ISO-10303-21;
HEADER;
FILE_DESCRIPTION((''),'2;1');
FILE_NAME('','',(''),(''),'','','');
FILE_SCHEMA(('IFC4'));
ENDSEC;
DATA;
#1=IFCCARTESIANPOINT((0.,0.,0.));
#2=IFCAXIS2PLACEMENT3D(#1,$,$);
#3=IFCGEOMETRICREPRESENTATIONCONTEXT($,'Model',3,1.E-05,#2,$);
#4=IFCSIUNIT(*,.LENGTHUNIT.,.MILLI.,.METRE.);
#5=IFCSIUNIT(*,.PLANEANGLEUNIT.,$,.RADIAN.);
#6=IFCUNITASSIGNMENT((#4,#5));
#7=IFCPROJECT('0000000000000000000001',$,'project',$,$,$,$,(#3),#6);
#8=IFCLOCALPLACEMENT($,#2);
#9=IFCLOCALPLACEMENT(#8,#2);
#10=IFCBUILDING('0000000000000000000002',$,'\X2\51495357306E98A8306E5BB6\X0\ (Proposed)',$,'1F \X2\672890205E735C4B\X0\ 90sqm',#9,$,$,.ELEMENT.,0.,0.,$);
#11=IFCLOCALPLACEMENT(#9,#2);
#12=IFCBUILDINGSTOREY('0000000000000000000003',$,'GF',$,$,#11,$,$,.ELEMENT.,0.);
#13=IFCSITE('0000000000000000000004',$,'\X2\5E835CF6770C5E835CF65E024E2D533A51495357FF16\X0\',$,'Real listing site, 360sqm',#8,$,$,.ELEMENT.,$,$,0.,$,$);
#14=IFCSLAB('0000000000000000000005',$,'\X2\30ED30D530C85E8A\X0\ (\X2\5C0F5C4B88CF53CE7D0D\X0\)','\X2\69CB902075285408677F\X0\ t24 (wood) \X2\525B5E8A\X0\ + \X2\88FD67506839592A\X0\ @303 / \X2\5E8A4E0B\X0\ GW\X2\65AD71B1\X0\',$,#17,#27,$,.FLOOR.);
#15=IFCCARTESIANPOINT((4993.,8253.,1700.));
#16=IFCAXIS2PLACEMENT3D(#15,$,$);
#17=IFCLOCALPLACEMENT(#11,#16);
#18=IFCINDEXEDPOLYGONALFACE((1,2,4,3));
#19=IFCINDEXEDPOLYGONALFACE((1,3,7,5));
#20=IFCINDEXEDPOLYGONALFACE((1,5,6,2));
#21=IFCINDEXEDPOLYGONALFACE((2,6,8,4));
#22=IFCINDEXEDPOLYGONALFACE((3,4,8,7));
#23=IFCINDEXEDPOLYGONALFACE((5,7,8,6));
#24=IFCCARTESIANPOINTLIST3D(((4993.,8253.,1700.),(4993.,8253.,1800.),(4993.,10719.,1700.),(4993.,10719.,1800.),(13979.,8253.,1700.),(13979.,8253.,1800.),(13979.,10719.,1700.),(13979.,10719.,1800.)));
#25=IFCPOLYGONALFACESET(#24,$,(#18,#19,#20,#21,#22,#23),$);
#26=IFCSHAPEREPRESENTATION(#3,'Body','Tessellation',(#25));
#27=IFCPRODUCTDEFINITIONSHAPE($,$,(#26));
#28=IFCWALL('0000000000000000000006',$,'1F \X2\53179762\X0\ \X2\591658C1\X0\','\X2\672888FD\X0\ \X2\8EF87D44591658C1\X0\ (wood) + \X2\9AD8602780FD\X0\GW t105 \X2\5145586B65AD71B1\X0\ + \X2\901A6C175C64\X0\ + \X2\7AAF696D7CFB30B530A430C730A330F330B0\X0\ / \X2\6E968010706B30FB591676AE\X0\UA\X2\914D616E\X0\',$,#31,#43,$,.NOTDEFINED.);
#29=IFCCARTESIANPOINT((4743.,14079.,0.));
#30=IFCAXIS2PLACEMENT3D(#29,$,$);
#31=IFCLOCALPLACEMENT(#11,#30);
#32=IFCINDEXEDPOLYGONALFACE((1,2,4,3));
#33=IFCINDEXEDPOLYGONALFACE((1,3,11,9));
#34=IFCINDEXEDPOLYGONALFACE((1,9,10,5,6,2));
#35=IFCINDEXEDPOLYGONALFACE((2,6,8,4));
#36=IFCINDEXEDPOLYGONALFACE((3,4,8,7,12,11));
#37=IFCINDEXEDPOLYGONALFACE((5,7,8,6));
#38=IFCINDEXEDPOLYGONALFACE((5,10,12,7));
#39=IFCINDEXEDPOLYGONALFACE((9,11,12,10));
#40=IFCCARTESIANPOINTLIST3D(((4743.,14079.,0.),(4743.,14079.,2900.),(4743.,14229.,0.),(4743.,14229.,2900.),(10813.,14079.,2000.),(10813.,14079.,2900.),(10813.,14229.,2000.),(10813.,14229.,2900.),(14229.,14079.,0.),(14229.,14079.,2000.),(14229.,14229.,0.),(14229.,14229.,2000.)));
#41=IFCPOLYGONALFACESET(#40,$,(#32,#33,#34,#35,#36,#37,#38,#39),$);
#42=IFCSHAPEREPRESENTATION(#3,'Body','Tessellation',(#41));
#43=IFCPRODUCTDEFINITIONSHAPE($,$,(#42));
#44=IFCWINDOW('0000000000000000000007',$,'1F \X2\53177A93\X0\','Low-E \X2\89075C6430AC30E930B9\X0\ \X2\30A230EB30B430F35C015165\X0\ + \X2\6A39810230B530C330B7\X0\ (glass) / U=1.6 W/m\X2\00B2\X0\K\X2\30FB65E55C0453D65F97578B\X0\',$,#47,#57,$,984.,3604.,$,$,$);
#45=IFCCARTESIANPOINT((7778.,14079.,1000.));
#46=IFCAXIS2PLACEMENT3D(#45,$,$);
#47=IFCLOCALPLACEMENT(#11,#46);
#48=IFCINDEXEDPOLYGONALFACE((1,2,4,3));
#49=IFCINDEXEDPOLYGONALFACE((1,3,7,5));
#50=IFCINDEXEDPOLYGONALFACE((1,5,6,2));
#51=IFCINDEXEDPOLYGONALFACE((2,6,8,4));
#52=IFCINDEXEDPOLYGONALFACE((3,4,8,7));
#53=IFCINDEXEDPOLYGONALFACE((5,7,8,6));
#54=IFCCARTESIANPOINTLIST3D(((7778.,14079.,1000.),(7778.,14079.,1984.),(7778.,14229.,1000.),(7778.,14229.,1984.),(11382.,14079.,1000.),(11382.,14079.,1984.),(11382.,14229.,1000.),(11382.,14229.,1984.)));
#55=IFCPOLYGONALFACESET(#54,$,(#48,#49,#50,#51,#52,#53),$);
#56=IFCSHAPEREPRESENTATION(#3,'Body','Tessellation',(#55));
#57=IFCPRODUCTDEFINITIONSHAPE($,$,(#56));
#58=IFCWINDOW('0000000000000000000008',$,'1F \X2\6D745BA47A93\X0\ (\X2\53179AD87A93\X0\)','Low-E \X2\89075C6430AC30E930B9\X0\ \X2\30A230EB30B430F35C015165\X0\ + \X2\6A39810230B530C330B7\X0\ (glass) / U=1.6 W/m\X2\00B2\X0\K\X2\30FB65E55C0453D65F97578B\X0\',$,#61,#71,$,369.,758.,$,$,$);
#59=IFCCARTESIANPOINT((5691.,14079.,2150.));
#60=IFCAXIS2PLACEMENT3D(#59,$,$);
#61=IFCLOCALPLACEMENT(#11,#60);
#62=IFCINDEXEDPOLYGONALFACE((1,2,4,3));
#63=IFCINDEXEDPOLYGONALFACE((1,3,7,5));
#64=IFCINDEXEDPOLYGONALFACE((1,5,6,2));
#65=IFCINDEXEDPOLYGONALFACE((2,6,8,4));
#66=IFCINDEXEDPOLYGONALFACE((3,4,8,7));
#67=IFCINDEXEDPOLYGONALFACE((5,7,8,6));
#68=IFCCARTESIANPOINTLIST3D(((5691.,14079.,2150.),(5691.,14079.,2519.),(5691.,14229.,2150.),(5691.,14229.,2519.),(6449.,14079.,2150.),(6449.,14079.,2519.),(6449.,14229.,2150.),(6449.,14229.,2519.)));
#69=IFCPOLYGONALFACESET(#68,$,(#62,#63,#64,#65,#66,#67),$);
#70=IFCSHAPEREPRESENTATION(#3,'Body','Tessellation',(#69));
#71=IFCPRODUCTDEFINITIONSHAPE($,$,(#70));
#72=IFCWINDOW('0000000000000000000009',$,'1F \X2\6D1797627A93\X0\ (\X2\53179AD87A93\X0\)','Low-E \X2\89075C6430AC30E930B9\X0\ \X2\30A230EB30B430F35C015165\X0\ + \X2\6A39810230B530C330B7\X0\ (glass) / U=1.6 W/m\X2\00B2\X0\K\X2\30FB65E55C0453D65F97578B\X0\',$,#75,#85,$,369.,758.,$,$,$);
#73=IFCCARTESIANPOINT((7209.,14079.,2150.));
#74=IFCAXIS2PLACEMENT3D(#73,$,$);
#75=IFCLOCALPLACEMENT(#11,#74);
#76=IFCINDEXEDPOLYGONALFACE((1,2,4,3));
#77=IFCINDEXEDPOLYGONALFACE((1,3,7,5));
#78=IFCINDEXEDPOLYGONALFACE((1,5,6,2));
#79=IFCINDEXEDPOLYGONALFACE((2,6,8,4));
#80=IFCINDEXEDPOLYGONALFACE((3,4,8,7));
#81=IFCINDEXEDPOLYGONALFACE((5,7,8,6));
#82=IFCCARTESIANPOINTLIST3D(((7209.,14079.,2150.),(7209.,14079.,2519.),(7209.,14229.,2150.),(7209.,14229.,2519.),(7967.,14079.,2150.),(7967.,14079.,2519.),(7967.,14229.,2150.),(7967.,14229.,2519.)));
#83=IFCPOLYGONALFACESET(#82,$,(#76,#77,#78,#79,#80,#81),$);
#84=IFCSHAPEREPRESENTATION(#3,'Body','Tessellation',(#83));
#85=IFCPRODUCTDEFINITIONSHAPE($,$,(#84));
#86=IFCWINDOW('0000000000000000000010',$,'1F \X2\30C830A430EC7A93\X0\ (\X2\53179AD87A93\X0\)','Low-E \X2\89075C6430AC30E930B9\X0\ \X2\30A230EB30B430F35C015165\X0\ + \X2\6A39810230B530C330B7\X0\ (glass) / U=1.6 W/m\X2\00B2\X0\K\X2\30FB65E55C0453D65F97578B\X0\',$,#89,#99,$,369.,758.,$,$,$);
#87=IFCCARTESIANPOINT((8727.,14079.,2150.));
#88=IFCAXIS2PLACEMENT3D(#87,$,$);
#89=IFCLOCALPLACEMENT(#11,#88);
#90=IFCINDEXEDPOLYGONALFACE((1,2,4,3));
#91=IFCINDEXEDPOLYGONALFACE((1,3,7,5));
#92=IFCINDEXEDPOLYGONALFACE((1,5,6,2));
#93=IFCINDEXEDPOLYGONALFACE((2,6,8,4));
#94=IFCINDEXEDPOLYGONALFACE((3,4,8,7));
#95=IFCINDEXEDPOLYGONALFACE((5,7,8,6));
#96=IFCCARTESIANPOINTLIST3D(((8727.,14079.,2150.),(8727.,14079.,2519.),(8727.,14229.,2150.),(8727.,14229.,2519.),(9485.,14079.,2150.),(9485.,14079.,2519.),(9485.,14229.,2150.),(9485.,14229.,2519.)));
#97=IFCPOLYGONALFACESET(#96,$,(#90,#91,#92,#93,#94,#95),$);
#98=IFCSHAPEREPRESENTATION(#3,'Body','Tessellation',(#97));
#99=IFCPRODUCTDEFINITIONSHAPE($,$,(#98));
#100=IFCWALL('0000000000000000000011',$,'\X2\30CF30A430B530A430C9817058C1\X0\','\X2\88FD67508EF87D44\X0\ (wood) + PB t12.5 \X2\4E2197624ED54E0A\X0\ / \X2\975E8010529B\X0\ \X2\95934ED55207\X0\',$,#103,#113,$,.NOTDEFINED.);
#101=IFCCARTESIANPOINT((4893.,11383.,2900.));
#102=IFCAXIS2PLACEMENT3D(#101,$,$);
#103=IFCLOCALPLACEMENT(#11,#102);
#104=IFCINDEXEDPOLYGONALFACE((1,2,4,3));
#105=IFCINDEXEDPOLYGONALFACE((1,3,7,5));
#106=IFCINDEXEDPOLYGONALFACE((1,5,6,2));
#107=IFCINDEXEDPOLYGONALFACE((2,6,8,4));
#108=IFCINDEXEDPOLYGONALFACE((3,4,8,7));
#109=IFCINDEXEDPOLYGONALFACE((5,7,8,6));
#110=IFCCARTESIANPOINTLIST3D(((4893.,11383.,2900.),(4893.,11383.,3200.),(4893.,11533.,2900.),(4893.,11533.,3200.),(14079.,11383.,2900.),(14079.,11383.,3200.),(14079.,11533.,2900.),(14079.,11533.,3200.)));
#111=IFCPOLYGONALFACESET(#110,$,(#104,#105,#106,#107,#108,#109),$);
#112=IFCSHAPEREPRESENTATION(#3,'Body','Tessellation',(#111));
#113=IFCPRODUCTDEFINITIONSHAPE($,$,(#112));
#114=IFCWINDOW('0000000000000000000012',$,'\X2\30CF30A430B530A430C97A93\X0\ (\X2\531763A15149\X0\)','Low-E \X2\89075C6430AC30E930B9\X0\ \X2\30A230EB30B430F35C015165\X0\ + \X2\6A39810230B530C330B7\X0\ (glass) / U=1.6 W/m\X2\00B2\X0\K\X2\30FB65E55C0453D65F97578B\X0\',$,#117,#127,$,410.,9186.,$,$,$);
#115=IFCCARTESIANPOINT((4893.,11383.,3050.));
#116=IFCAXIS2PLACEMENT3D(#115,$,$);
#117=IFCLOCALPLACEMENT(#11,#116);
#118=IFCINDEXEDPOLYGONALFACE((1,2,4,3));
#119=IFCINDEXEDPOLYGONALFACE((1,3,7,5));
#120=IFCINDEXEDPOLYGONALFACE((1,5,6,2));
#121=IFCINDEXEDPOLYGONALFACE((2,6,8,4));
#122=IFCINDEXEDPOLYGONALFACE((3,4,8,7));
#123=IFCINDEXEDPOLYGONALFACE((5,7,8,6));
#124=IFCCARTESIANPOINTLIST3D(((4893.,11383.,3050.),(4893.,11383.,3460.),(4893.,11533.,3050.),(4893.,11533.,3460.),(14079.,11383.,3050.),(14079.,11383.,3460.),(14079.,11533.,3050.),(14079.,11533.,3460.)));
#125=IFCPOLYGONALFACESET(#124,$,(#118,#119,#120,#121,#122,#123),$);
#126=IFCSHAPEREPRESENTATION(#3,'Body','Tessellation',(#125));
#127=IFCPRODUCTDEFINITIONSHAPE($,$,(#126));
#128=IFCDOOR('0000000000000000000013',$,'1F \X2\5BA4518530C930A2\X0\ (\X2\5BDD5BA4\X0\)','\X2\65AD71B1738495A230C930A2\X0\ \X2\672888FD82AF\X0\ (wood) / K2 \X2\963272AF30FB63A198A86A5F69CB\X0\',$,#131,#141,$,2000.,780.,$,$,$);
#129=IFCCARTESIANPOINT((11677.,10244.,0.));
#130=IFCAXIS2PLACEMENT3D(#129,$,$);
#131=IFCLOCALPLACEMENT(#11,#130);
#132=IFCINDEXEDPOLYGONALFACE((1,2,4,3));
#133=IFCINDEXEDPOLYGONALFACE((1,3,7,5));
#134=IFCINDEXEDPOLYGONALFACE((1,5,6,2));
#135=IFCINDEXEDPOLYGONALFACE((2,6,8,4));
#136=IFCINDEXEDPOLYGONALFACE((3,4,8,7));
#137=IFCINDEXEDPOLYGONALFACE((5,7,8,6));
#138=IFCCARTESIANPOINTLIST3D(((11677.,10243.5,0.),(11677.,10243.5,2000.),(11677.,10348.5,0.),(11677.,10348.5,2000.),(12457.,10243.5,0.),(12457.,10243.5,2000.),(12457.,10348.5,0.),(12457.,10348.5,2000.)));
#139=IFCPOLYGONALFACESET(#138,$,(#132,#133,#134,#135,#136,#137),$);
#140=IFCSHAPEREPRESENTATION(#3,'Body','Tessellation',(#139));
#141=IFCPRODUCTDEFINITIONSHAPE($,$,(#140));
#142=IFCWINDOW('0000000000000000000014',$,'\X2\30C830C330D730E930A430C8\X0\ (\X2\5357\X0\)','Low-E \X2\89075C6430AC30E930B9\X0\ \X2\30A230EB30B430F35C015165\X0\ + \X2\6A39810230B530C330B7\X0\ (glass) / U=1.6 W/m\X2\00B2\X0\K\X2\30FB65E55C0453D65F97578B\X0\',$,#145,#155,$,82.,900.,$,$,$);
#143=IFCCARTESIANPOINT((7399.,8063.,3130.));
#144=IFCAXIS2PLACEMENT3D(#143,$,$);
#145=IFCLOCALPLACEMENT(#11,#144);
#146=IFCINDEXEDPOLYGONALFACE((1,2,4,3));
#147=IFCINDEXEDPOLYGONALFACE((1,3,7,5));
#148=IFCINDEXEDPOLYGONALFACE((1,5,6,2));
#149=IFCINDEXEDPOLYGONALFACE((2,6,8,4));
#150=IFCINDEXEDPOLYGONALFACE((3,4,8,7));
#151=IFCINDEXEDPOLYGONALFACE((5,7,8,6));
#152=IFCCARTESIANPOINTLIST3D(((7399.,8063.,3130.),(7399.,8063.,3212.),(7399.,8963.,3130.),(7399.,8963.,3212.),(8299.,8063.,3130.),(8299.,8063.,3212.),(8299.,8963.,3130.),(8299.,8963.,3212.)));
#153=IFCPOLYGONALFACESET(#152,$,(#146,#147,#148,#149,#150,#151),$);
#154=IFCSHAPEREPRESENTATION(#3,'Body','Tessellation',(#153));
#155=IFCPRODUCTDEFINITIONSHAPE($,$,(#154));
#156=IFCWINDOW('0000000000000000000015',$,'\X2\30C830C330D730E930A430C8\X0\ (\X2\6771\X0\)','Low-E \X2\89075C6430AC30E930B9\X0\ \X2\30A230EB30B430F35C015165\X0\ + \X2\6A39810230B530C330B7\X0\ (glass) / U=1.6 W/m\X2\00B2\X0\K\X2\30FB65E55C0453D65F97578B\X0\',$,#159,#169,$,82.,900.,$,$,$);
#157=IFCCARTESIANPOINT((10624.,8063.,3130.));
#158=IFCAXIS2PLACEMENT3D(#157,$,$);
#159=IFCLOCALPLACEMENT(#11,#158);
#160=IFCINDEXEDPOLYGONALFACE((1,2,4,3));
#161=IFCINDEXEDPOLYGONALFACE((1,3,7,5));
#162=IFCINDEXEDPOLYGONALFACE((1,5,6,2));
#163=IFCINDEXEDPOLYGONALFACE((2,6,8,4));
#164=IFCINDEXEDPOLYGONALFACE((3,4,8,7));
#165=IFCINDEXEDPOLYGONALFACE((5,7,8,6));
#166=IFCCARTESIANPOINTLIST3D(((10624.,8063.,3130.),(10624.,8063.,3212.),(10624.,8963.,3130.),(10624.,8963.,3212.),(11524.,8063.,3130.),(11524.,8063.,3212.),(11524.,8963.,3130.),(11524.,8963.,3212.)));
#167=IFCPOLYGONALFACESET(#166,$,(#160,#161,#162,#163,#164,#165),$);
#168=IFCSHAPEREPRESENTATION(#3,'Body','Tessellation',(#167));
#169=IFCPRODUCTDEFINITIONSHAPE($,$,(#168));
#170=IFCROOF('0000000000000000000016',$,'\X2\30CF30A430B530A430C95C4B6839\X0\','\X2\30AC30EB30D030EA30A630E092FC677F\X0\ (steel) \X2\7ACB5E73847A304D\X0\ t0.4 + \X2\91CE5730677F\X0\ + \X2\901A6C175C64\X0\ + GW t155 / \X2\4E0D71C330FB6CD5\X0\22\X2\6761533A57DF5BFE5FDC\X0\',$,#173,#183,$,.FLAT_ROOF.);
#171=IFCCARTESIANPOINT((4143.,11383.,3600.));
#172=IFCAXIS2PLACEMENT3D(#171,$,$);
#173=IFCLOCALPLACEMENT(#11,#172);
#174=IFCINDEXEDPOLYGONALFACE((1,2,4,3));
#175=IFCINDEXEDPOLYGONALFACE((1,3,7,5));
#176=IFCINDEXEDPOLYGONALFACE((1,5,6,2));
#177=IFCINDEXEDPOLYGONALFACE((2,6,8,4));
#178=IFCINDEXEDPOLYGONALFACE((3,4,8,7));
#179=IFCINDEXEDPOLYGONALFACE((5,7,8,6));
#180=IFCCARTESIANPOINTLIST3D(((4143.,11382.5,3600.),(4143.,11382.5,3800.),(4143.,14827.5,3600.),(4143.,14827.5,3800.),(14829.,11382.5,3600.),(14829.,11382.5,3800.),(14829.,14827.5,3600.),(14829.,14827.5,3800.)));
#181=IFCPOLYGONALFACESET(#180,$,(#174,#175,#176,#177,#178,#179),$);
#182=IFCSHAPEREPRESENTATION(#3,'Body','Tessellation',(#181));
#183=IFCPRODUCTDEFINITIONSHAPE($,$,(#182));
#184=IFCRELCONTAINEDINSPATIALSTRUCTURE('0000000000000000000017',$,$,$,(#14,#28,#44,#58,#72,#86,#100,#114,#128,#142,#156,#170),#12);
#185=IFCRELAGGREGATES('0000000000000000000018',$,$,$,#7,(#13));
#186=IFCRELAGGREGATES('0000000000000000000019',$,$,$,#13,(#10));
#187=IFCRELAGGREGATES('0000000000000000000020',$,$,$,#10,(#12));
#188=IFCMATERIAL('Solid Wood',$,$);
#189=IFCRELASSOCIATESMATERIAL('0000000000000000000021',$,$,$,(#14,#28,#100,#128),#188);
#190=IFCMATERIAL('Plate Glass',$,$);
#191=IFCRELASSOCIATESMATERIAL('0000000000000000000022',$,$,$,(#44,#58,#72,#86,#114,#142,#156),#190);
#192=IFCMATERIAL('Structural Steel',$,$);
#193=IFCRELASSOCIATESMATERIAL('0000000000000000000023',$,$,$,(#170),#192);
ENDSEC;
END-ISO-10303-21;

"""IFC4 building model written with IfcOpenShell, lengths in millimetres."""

from ifc_helpers import new_model, si_unit, frame, frame_2d, origin, place, context, project, spatial, rectangle, extrude, material, element, fill, save


model = new_model("IFC4")

# Units and contexts
model_context = context("Model", 3, precision=1e-05, world=origin())
ifc_project = project(units=[si_unit("LENGTHUNIT", "METRE", prefix="MILLI"), si_unit("PLANEANGLEUNIT", "RADIAN")], contexts=[model_context])

# Site, building, storey
site_placement = place(None, origin())
site = spatial("IfcSite", under=ifc_project, at=site_placement, Name="広島県広島市中区光南６", ObjectType="Real listing site, 360sqm", CompositionType="ELEMENT", RefElevation=0.0)
building_placement = place(site_placement, origin())
building = spatial("IfcBuilding", under=site, at=building_placement, Name="光南の風の家 (Proposed)", ObjectType="1F 木造平屋 90sqm", CompositionType="ELEMENT", ElevationOfRefHeight=0.0, ElevationOfTerrain=0.0)
storey_placement = place(building_placement, origin())
storey = spatial("IfcBuildingStorey", under=building, at=storey_placement, Name="GF", CompositionType="ELEMENT", Elevation=0.0)

# Slab
ifc_material_1 = material(Name="Solid Wood")
slab_placement = place(storey_placement, frame((4993.0, 8253.0, 1700.0)))
element("IfcSlab", 1, at=slab_placement, inside=storey, material=ifc_material_1, Name="ロフト床 (小屋裏収納)", Description="構造用合板 t24 (wood) 剛床 + 製材根太 @303 / 床下 GW断熱", PredefinedType="FLOOR", context=model_context, shape_type="SweptSolid", body=[
    extrude(rectangle(XDim=8986.0, YDim=2466.0, at=frame_2d((4493.0, 1233.0))), frame((4993.0, 8253.0, 1700.0)), (0.0, 0.0, 1.0), 100.0),
])

# Wall, openings, windows
wall_1_placement = place(storey_placement, frame((4743.0, 14079.0, 0.0)))
wall_1 = element("IfcWall", 2, at=wall_1_placement, inside=storey, material=ifc_material_1, Name="1F 北面 外壁", Description="木製 軸組外壁 (wood) + 高性能GW t105 充填断熱 + 通気層 + 窯業系サイディング / 準耐火・外皮UA配慮", PredefinedType="NOTDEFINED", context=model_context, shape_type="SweptSolid", body=[
    extrude(rectangle(XDim=9486.0, YDim=150.0, at=frame_2d((4743.0, 75.0))), frame((4743.0, 14079.0, 0.0)), (0.0, 0.0, 1.0), 2900.0),
])
opening_1_placement = place(storey_placement, frame((7778.0, 14079.0, 1000.0)))
opening_1 = element("IfcOpeningElement", 3, at=opening_1_placement, cuts=wall_1, PredefinedType="NOTDEFINED", context=model_context, shape_type="SweptSolid", body=[
    extrude(rectangle(XDim=3604.0, YDim=150.0, at=frame_2d((1802.0, 75.0))), frame((7778.0, 14079.0, 1000.0)), (0.0, 0.0, 1.0), 984.0),
])
opening_2_placement = place(storey_placement, frame((5691.0, 14079.0, 2150.0)))
opening_2 = element("IfcOpeningElement", 4, at=opening_2_placement, cuts=wall_1, PredefinedType="NOTDEFINED", context=model_context, shape_type="SweptSolid", body=[
    extrude(rectangle(XDim=758.0, YDim=150.0, at=frame_2d((379.0, 75.0))), frame((5691.0, 14079.0, 2150.0)), (0.0, 0.0, 1.0), 369.0),
])
opening_3_placement = place(storey_placement, frame((7209.0, 14079.0, 2150.0)))
opening_3 = element("IfcOpeningElement", 5, at=opening_3_placement, cuts=wall_1, PredefinedType="NOTDEFINED", context=model_context, shape_type="SweptSolid", body=[
    extrude(rectangle(XDim=758.0, YDim=150.0, at=frame_2d((379.0, 75.0))), frame((7209.0, 14079.0, 2150.0)), (0.0, 0.0, 1.0), 369.0),
])
opening_4_placement = place(storey_placement, frame((8727.0, 14079.0, 2150.0)))
opening_4 = element("IfcOpeningElement", 6, at=opening_4_placement, cuts=wall_1, PredefinedType="NOTDEFINED", context=model_context, shape_type="SweptSolid", body=[
    extrude(rectangle(XDim=758.0, YDim=150.0, at=frame_2d((379.0, 75.0))), frame((8727.0, 14079.0, 2150.0)), (0.0, 0.0, 1.0), 369.0),
])
ifc_material_2 = material(Name="Plate Glass")
window_1_placement = place(storey_placement, frame((7778.0, 14079.0, 1000.0)))
window_1 = element("IfcWindow", 7, at=window_1_placement, inside=storey, material=ifc_material_2, Name="1F 北窓", Description="Low-E 複層ガラス アルゴン封入 + 樹脂サッシ (glass) / U=1.6 W/m²K・日射取得型", OverallHeight=984.0, OverallWidth=3604.0, context=model_context, shape_type="SweptSolid", body=[
    extrude(rectangle(XDim=3604.0, YDim=150.0, at=frame_2d((1802.0, 75.0))), frame((7778.0, 14079.0, 1000.0)), (0.0, 0.0, 1.0), 984.0),
])
fill(opening_1, window_1)
window_2_placement = place(storey_placement, frame((5691.0, 14079.0, 2150.0)))
window_2 = element("IfcWindow", 8, at=window_2_placement, inside=storey, material=ifc_material_2, Name="1F 浴室窓 (北高窓)", Description="Low-E 複層ガラス アルゴン封入 + 樹脂サッシ (glass) / U=1.6 W/m²K・日射取得型", OverallHeight=369.0, OverallWidth=758.0, context=model_context, shape_type="SweptSolid", body=[
    extrude(rectangle(XDim=758.0, YDim=150.0, at=frame_2d((379.0, 75.0))), frame((5691.0, 14079.0, 2150.0)), (0.0, 0.0, 1.0), 369.0),
])
fill(opening_2, window_2)
window_3_placement = place(storey_placement, frame((7209.0, 14079.0, 2150.0)))
window_3 = element("IfcWindow", 9, at=window_3_placement, inside=storey, material=ifc_material_2, Name="1F 洗面窓 (北高窓)", Description="Low-E 複層ガラス アルゴン封入 + 樹脂サッシ (glass) / U=1.6 W/m²K・日射取得型", OverallHeight=369.0, OverallWidth=758.0, context=model_context, shape_type="SweptSolid", body=[
    extrude(rectangle(XDim=758.0, YDim=150.0, at=frame_2d((379.0, 75.0))), frame((7209.0, 14079.0, 2150.0)), (0.0, 0.0, 1.0), 369.0),
])
fill(opening_3, window_3)
window_4_placement = place(storey_placement, frame((8727.0, 14079.0, 2150.0)))
window_4 = element("IfcWindow", 10, at=window_4_placement, inside=storey, material=ifc_material_2, Name="1F トイレ窓 (北高窓)", Description="Low-E 複層ガラス アルゴン封入 + 樹脂サッシ (glass) / U=1.6 W/m²K・日射取得型", OverallHeight=369.0, OverallWidth=758.0, context=model_context, shape_type="SweptSolid", body=[
    extrude(rectangle(XDim=758.0, YDim=150.0, at=frame_2d((379.0, 75.0))), frame((8727.0, 14079.0, 2150.0)), (0.0, 0.0, 1.0), 369.0),
])
fill(opening_4, window_4)

# Wall, opening, window
wall_2_placement = place(storey_placement, frame((4893.0, 11383.0, 2900.0)))
wall_2 = element("IfcWall", 11, at=wall_2_placement, inside=storey, material=ifc_material_1, Name="ハイサイド腰壁", Description="製材軸組 (wood) + PB t12.5 両面仕上 / 非耐力 間仕切", PredefinedType="NOTDEFINED", context=model_context, shape_type="SweptSolid", body=[
    extrude(rectangle(XDim=9186.0, YDim=150.0, at=frame_2d((4593.0, 75.0))), frame((4893.0, 11383.0, 2900.0)), (0.0, 0.0, 1.0), 700.0),
])
opening_5_placement = place(storey_placement, frame((4893.0, 11383.0, 3050.0)))
opening_5 = element("IfcOpeningElement", 12, at=opening_5_placement, cuts=wall_2, PredefinedType="NOTDEFINED", context=model_context, shape_type="SweptSolid", body=[
    extrude(rectangle(XDim=9186.0, YDim=150.0, at=frame_2d((4593.0, 75.0))), frame((4893.0, 11383.0, 3050.0)), (0.0, 0.0, 1.0), 410.0),
])
window_5_placement = place(storey_placement, frame((4893.0, 11383.0, 3050.0)))
window_5 = element("IfcWindow", 13, at=window_5_placement, inside=storey, material=ifc_material_2, Name="ハイサイド窓 (北採光)", Description="Low-E 複層ガラス アルゴン封入 + 樹脂サッシ (glass) / U=1.6 W/m²K・日射取得型", OverallHeight=410.0, OverallWidth=9186.0, context=model_context, shape_type="SweptSolid", body=[
    extrude(rectangle(XDim=9186.0, YDim=150.0, at=frame_2d((4593.0, 75.0))), frame((4893.0, 11383.0, 3050.0)), (0.0, 0.0, 1.0), 410.0),
])
fill(opening_5, window_5)

# Door
door_1_placement = place(storey_placement, frame((11677.0, 10244.0, 0.0)))
element("IfcDoor", 14, at=door_1_placement, inside=storey, material=ifc_material_1, Name="1F 室内ドア (寝室)", Description="断熱玄関ドア 木製芯 (wood) / K2 防犯・採風機構", OverallHeight=2000.0, OverallWidth=780.0, context=model_context, shape_type="SweptSolid", body=[
    extrude(rectangle(XDim=780.0, YDim=105.0, at=frame_2d((390.0, 52.0))), frame((11677.0, 10244.0, 0.0)), (0.0, 0.0, 1.0), 2000.0),
])

# Windows
window_6_placement = place(storey_placement, frame((7399.0, 8063.0, 3130.0)))
element("IfcWindow", 15, at=window_6_placement, inside=storey, material=ifc_material_2, Name="トップライト (南)", Description="Low-E 複層ガラス アルゴン封入 + 樹脂サッシ (glass) / U=1.6 W/m²K・日射取得型", OverallHeight=82.0, OverallWidth=900.0, context=model_context, shape_type="SweptSolid", body=[
    extrude(rectangle(XDim=900.0, YDim=900.0, at=frame_2d((450.0, 450.0))), frame((7399.0, 8063.0, 3130.0)), (0.0, 0.0, 1.0), 82.0),
])
window_7_placement = place(storey_placement, frame((10624.0, 8063.0, 3130.0)))
element("IfcWindow", 16, at=window_7_placement, inside=storey, material=ifc_material_2, Name="トップライト (東)", Description="Low-E 複層ガラス アルゴン封入 + 樹脂サッシ (glass) / U=1.6 W/m²K・日射取得型", OverallHeight=82.0, OverallWidth=900.0, context=model_context, shape_type="SweptSolid", body=[
    extrude(rectangle(XDim=900.0, YDim=900.0, at=frame_2d((450.0, 450.0))), frame((10624.0, 8063.0, 3130.0)), (0.0, 0.0, 1.0), 82.0),
])

# Roof
ifc_material_3 = material(Name="Structural Steel")
roof_placement = place(storey_placement, frame((4143.0, 11383.0, 3600.0)))
element("IfcRoof", 17, at=roof_placement, inside=storey, material=ifc_material_3, Name="ハイサイド屋根", Description="ガルバリウム鋼板 (steel) 立平葺き t0.4 + 野地板 + 通気層 + GW t155 / 不燃・法22条区域対応", PredefinedType="FLAT_ROOF", context=model_context, shape_type="SweptSolid", body=[
    extrude(rectangle(XDim=10686.0, YDim=3445.0, at=frame_2d((5343.0, 1722.0))), frame((4143.0, 11383.0, 3600.0)), (0.0, 0.0, 1.0), 200.0),
])

save(model, "model.ifc")
